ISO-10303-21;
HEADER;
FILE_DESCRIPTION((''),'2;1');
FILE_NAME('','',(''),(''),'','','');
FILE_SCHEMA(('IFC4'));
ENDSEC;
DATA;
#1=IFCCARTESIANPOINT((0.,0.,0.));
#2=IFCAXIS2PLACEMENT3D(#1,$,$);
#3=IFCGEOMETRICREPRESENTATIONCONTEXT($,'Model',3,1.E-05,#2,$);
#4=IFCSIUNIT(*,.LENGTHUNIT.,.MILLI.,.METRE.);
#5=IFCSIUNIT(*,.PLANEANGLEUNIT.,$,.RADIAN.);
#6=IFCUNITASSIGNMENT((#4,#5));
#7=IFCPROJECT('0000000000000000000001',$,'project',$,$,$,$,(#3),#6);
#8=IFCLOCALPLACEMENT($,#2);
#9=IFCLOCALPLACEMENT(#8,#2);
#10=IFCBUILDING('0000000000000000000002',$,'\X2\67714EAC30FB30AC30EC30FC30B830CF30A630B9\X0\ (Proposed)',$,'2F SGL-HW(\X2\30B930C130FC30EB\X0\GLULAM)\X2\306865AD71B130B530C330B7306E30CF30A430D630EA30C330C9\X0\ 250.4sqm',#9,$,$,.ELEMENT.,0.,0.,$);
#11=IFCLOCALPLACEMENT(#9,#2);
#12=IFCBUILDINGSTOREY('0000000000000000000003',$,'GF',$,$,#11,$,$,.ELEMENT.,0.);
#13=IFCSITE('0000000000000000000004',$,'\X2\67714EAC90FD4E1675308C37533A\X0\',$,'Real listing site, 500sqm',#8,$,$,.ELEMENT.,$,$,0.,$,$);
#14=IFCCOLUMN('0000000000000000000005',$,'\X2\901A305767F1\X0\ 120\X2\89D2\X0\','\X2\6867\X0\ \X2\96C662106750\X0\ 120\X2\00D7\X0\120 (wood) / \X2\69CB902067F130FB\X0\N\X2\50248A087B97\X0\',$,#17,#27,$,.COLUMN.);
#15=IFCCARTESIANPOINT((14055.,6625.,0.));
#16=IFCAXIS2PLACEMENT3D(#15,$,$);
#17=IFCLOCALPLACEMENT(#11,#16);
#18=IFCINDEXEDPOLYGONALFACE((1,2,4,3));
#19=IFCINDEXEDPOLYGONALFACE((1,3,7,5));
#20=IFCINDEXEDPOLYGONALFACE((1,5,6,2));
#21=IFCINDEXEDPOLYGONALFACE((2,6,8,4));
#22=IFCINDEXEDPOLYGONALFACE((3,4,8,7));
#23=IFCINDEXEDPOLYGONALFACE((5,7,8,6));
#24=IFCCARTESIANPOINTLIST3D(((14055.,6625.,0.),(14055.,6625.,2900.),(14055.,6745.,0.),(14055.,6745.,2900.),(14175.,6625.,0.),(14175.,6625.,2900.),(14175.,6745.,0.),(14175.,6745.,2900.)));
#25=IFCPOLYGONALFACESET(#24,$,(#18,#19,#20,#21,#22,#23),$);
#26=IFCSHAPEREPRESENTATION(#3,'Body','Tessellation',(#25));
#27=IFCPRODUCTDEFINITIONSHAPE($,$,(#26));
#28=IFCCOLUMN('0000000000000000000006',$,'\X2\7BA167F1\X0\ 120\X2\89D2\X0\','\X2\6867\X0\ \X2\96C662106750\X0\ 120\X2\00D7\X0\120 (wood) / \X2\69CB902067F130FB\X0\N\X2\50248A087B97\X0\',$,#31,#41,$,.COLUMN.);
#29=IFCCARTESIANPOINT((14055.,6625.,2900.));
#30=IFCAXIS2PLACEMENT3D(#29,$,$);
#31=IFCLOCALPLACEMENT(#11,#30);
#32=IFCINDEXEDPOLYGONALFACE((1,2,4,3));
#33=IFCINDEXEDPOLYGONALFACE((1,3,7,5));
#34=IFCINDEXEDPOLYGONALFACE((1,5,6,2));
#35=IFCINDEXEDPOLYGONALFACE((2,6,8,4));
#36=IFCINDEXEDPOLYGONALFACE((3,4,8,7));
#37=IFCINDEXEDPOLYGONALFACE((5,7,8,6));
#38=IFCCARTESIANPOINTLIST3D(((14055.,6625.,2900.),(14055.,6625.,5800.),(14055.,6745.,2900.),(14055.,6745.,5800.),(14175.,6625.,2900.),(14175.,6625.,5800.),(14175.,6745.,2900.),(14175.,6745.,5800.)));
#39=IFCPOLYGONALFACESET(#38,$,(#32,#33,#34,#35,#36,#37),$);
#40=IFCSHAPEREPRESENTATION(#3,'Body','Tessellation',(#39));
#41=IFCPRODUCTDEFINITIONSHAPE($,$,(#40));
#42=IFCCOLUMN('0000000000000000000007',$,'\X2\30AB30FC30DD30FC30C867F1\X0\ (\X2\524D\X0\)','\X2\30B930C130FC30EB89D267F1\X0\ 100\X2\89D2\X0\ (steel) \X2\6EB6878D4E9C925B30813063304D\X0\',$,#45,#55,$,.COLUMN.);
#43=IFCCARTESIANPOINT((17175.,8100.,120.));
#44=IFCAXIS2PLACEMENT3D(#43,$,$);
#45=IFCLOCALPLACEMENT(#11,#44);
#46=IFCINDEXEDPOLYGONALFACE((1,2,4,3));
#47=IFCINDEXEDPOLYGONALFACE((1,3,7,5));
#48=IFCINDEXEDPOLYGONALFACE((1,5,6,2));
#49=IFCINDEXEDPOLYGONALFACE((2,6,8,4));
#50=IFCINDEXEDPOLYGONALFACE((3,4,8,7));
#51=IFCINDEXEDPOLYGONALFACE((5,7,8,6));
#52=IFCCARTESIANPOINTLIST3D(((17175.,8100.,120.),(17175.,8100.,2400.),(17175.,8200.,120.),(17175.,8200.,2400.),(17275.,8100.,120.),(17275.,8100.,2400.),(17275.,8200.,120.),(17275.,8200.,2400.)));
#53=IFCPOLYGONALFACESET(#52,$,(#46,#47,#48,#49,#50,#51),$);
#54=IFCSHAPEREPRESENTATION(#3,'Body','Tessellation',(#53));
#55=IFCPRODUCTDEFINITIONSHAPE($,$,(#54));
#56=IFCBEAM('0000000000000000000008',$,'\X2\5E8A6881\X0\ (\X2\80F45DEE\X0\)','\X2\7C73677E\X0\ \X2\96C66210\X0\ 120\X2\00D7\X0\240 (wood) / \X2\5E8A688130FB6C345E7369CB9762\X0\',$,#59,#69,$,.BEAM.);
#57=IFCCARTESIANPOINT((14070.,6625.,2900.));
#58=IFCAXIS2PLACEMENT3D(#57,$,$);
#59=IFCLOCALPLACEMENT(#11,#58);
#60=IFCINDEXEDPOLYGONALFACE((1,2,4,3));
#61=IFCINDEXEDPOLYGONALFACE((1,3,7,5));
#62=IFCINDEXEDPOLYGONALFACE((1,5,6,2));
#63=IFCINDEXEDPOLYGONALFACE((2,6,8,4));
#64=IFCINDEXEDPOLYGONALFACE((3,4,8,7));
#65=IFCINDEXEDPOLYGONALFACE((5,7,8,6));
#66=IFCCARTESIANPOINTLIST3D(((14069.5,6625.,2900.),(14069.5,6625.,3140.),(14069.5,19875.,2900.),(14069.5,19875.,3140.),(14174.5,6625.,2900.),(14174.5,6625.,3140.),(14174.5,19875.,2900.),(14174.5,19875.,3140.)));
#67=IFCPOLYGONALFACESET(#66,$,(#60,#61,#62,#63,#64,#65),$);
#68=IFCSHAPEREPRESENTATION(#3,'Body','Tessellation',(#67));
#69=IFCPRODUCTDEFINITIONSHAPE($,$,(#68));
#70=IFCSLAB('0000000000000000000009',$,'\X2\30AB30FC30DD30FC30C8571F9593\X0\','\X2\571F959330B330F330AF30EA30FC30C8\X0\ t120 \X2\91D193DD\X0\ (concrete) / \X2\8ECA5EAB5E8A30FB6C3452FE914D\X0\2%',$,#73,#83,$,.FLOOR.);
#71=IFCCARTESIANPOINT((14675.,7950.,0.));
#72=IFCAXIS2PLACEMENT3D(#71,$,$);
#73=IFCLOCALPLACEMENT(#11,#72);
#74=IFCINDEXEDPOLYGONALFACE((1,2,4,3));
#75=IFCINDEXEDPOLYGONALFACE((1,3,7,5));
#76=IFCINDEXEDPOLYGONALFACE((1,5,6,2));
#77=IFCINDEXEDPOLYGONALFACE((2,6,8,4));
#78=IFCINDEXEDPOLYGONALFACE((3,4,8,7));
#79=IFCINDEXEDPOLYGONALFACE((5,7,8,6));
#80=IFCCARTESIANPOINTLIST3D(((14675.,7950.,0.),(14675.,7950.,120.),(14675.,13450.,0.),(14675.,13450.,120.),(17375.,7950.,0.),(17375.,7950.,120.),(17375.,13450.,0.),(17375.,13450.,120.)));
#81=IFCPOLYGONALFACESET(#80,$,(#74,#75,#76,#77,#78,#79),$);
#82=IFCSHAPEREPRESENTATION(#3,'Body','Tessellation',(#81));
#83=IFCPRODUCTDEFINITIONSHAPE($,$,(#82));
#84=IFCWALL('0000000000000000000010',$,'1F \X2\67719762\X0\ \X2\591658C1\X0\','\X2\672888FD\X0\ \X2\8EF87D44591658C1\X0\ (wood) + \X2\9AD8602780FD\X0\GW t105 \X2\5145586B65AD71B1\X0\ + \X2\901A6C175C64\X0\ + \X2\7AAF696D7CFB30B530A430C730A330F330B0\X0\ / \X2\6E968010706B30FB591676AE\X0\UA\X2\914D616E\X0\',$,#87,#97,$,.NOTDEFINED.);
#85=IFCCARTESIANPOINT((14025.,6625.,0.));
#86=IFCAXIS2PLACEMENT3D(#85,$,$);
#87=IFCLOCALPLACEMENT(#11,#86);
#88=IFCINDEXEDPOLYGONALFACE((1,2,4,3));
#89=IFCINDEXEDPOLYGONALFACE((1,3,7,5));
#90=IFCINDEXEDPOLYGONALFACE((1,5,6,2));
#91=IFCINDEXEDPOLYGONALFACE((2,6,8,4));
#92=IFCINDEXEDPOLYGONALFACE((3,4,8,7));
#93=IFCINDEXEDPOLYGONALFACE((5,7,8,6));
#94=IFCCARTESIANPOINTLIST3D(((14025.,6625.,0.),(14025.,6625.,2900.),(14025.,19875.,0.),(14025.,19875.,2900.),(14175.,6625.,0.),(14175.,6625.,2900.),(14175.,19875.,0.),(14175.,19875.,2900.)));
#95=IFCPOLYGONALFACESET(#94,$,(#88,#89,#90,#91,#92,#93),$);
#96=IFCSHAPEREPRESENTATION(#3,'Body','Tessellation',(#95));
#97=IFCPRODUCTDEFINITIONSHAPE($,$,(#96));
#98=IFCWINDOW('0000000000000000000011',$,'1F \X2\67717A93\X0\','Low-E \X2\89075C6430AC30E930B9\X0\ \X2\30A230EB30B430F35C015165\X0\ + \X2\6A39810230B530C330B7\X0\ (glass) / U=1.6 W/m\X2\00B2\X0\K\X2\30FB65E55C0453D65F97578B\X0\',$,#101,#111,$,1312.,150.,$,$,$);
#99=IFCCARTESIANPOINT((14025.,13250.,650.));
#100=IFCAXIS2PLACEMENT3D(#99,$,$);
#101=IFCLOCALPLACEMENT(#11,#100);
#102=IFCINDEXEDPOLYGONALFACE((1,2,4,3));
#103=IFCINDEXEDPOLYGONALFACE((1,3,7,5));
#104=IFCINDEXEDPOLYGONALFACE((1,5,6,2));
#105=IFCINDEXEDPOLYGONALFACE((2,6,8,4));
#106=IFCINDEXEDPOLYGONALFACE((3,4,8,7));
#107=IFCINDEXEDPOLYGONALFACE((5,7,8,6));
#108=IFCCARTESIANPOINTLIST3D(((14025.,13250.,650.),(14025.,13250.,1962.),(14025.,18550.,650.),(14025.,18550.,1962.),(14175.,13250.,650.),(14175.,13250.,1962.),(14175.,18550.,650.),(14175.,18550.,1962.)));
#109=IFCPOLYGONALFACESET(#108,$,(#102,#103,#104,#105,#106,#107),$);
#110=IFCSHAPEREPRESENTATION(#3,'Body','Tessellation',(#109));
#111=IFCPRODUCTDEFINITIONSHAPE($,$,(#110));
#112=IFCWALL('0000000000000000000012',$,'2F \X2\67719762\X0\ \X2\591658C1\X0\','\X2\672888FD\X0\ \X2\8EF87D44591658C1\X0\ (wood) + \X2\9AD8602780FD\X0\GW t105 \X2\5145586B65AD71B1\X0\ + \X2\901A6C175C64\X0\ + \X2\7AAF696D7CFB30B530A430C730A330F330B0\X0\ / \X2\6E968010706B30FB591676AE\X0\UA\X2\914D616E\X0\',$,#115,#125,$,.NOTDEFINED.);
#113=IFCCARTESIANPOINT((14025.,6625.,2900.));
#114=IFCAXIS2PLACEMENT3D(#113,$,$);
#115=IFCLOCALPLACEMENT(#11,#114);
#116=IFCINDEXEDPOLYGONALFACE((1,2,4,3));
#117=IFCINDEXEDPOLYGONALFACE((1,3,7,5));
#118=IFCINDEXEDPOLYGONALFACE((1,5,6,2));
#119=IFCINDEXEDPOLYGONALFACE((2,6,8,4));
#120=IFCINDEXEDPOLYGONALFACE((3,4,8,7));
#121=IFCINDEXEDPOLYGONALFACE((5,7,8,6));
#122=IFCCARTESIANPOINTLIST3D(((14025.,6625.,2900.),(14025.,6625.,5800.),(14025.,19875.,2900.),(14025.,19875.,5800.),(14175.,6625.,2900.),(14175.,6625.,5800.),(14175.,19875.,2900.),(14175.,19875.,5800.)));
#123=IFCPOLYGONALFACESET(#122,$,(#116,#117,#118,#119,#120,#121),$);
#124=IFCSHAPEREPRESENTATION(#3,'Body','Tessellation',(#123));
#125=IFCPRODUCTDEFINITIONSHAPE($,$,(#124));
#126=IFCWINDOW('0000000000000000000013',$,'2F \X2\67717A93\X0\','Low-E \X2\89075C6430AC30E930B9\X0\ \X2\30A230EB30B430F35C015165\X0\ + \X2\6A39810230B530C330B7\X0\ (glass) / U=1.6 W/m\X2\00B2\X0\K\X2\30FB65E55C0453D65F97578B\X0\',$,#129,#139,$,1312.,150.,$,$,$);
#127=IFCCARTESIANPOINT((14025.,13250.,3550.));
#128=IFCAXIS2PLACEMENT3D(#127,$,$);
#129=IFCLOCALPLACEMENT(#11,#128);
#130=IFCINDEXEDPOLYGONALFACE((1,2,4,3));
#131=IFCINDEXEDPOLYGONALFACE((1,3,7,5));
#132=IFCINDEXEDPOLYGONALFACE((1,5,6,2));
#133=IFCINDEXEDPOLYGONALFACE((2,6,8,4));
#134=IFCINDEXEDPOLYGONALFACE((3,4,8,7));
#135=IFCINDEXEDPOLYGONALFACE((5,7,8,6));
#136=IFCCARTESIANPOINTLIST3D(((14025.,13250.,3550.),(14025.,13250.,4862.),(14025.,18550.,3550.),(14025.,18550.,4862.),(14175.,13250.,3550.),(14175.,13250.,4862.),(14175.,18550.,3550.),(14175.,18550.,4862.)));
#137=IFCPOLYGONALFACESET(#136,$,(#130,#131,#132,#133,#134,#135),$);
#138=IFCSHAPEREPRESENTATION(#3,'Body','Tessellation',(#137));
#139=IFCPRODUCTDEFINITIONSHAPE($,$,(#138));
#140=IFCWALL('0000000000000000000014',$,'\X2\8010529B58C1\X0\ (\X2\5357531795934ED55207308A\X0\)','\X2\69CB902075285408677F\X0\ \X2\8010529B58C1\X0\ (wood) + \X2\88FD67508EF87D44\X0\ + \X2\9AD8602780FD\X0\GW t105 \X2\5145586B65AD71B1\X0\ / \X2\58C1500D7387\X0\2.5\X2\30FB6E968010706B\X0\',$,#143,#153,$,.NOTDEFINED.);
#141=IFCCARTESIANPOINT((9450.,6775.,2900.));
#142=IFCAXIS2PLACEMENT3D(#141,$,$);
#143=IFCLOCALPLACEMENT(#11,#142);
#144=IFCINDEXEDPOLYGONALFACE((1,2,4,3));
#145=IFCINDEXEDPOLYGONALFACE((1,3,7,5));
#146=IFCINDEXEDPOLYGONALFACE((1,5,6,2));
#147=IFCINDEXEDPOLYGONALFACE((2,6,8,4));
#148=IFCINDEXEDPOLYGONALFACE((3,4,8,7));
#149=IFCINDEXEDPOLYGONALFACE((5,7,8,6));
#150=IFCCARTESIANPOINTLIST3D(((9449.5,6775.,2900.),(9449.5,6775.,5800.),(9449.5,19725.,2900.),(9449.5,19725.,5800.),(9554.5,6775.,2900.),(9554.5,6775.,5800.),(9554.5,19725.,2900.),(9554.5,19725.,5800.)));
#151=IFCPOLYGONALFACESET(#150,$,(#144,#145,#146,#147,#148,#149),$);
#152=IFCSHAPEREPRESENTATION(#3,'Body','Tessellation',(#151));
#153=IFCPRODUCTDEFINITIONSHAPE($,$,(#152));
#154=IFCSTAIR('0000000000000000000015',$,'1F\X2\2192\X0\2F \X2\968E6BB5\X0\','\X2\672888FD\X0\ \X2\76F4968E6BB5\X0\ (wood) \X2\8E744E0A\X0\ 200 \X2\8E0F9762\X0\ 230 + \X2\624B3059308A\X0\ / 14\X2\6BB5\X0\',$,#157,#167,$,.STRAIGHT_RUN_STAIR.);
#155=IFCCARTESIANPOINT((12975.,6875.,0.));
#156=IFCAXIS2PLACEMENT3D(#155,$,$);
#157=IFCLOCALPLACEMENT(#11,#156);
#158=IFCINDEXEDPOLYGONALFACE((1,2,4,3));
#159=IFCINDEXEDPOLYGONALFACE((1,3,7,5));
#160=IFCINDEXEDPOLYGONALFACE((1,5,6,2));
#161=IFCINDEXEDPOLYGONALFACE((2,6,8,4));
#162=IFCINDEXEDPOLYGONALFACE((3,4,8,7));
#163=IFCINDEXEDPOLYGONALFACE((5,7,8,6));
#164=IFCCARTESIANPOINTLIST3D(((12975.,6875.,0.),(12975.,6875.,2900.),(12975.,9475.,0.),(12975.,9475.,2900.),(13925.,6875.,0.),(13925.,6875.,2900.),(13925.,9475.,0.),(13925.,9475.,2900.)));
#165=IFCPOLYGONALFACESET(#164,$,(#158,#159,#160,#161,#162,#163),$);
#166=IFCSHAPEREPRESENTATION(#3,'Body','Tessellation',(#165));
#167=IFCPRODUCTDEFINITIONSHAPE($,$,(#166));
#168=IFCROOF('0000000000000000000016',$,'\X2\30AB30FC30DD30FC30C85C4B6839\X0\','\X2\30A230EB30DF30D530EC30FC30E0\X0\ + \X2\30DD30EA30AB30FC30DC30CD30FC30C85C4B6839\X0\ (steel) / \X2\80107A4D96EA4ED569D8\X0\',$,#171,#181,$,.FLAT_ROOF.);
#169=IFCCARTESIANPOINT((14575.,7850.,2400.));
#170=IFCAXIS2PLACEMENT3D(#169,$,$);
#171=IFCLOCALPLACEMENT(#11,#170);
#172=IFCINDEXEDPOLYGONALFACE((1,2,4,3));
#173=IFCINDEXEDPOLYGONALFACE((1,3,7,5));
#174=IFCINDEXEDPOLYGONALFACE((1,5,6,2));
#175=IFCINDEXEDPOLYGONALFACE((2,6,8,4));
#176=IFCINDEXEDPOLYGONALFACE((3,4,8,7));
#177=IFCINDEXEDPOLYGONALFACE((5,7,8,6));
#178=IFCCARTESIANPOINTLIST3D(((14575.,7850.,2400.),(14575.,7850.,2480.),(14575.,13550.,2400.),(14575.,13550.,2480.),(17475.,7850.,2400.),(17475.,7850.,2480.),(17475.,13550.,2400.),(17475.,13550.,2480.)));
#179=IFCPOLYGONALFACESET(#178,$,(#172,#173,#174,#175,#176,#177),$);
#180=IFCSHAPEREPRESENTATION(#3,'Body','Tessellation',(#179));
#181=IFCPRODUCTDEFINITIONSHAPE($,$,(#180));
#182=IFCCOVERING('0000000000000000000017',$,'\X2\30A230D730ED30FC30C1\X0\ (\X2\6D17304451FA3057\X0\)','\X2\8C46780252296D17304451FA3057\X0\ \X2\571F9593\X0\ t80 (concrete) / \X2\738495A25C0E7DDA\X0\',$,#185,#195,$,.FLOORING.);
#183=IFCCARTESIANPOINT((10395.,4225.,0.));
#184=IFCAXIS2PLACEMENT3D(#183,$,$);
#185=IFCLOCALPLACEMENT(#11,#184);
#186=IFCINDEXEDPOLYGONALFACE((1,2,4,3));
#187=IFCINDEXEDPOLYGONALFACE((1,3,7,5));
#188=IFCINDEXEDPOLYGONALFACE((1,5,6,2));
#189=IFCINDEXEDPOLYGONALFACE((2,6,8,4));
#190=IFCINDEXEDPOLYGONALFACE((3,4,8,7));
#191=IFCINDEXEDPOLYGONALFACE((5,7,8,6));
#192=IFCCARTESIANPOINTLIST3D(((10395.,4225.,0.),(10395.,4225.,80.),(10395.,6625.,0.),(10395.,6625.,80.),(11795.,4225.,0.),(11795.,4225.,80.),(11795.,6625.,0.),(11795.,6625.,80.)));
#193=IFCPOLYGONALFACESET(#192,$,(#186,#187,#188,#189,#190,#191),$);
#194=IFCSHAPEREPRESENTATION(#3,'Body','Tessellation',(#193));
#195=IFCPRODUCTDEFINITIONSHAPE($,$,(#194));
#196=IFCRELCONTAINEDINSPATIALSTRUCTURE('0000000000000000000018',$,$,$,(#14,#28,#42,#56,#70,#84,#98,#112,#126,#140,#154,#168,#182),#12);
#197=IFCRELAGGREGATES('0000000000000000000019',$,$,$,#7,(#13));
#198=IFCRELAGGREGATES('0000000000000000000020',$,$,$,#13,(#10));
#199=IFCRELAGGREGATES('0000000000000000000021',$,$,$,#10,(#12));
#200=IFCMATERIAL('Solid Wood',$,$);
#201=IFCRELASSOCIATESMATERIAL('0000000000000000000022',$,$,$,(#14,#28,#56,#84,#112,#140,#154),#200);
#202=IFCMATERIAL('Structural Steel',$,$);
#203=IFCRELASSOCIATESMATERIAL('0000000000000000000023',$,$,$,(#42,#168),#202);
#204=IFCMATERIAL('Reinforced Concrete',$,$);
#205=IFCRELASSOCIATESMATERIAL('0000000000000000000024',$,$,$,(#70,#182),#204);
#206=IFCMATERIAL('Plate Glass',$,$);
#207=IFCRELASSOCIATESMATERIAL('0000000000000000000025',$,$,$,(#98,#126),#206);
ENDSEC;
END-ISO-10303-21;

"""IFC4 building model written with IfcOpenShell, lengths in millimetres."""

from ifc_helpers import new_model, si_unit, frame, frame_2d, origin, place, context, project, spatial, rectangle, extrude, material, element, fill, save


model = new_model("IFC4")

# Units and contexts
model_context = context("Model", 3, precision=1e-05, world=origin())
ifc_project = project(units=[si_unit("LENGTHUNIT", "METRE", prefix="MILLI"), si_unit("PLANEANGLEUNIT", "RADIAN")], contexts=[model_context])

# Site, building, storey
site_placement = place(None, origin())
site = spatial("IfcSite", under=ifc_project, at=site_placement, Name="東京都世田谷区", ObjectType="Real listing site, 500sqm", CompositionType="ELEMENT", RefElevation=0.0)
building_placement = place(site_placement, origin())
building = spatial("IfcBuilding", under=site, at=building_placement, Name="東京・ガレージハウス (Proposed)", ObjectType="2F SGL-HW(スチールGLULAM)と断熱サッシのハイブリッド 250.4sqm", CompositionType="ELEMENT", ElevationOfRefHeight=0.0, ElevationOfTerrain=0.0)
storey_placement = place(building_placement, origin())
storey = spatial("IfcBuildingStorey", under=building, at=storey_placement, Name="GF", CompositionType="ELEMENT", Elevation=0.0)

# Columns
ifc_material_1 = material(Name="Solid Wood")
column_1_placement = place(storey_placement, frame((14055.0, 6625.0, 0.0)))
element("IfcColumn", 1, at=column_1_placement, inside=storey, material=ifc_material_1, Name="通し柱 120角", Description="桧 集成材 120×120 (wood) / 構造柱・N値計算", PredefinedType="COLUMN", context=model_context, shape_type="SweptSolid", body=[
    extrude(rectangle(XDim=120.0, YDim=120.0, at=frame_2d((60.0, 60.0))), frame((14055.0, 6625.0, 0.0)), (0.0, 0.0, 1.0), 2900.0),
])
column_2_placement = place(storey_placement, frame((14055.0, 6625.0, 2900.0)))
element("IfcColumn", 2, at=column_2_placement, inside=storey, material=ifc_material_1, Name="管柱 120角", Description="桧 集成材 120×120 (wood) / 構造柱・N値計算", PredefinedType="COLUMN", context=model_context, shape_type="SweptSolid", body=[
    extrude(rectangle(XDim=120.0, YDim=120.0, at=frame_2d((60.0, 60.0))), frame((14055.0, 6625.0, 2900.0)), (0.0, 0.0, 1.0), 2900.0),
])
ifc_material_2 = material(Name="Structural Steel")
column_3_placement = place(storey_placement, frame((17175.0, 8100.0, 120.0)))
element("IfcColumn", 3, at=column_3_placement, inside=storey, material=ifc_material_2, Name="カーポート柱 (前)", Description="スチール角柱 100角 (steel) 溶融亜鉛めっき", PredefinedType="COLUMN", context=model_context, shape_type="SweptSolid", body=[
    extrude(rectangle(XDim=100.0, YDim=100.0, at=frame_2d((50.0, 50.0))), frame((17175.0, 8100.0, 120.0)), (0.0, 0.0, 1.0), 2280.0),
])

# Beam
beam_1_placement = place(storey_placement, frame((14070.0, 6625.0, 2900.0)))
element("IfcBeam", 4, at=beam_1_placement, inside=storey, material=ifc_material_1, Name="床梁 (胴差)", Description="米松 集成 120×240 (wood) / 床梁・水平構面", PredefinedType="BEAM", context=model_context, shape_type="SweptSolid", body=[
    extrude(rectangle(XDim=105.0, YDim=13250.0, at=frame_2d((52.0, 6625.0))), frame((14070.0, 6625.0, 2900.0)), (0.0, 0.0, 1.0), 240.0),
])

# Slab
ifc_material_3 = material(Name="Reinforced Concrete")
slab_placement = place(storey_placement, frame((14675.0, 7950.0, 0.0)))
element("IfcSlab", 5, at=slab_placement, inside=storey, material=ifc_material_3, Name="カーポート土間", Description="土間コンクリート t120 金鏝 (concrete) / 車庫床・水勾配2%", PredefinedType="FLOOR", context=model_context, shape_type="SweptSolid", body=[
    extrude(rectangle(XDim=2700.0, YDim=5500.0, at=frame_2d((1350.0, 2750.0))), frame((14675.0, 7950.0, 0.0)), (0.0, 0.0, 1.0), 120.0),
])

# Wall, opening, window
wall_1_placement = place(storey_placement, frame((14025.0, 6625.0, 0.0)))
wall_1 = element("IfcWall", 6, at=wall_1_placement, inside=storey, material=ifc_material_1, Name="1F 東面 外壁", Description="木製 軸組外壁 (wood) + 高性能GW t105 充填断熱 + 通気層 + 窯業系サイディング / 準耐火・外皮UA配慮", PredefinedType="NOTDEFINED", context=model_context, shape_type="SweptSolid", body=[
    extrude(rectangle(XDim=150.0, YDim=13250.0, at=frame_2d((75.0, 6625.0))), frame((14025.0, 6625.0, 0.0)), (0.0, 0.0, 1.0), 2900.0),
])
opening_1_placement = place(storey_placement, frame((14025.0, 13250.0, 650.0)))
opening_1 = element("IfcOpeningElement", 7, at=opening_1_placement, cuts=wall_1, PredefinedType="NOTDEFINED", context=model_context, shape_type="SweptSolid", body=[
    extrude(rectangle(XDim=150.0, YDim=5300.0, at=frame_2d((75.0, 2650.0))), frame((14025.0, 13250.0, 650.0)), (0.0, 0.0, 1.0), 1312.0),
])
ifc_material_4 = material(Name="Plate Glass")
window_1_placement = place(storey_placement, frame((14025.0, 13250.0, 650.0)))
window_1 = element("IfcWindow", 8, at=window_1_placement, inside=storey, material=ifc_material_4, Name="1F 東窓", Description="Low-E 複層ガラス アルゴン封入 + 樹脂サッシ (glass) / U=1.6 W/m²K・日射取得型", OverallHeight=1312.0, OverallWidth=150.0, context=model_context, shape_type="SweptSolid", body=[
    extrude(rectangle(XDim=150.0, YDim=5300.0, at=frame_2d((75.0, 2650.0))), frame((14025.0, 13250.0, 650.0)), (0.0, 0.0, 1.0), 1312.0),
])
fill(opening_1, window_1)

# Wall, opening, window
wall_2_placement = place(storey_placement, frame((14025.0, 6625.0, 2900.0)))
wall_2 = element("IfcWall", 9, at=wall_2_placement, inside=storey, material=ifc_material_1, Name="2F 東面 外壁", Description="木製 軸組外壁 (wood) + 高性能GW t105 充填断熱 + 通気層 + 窯業系サイディング / 準耐火・外皮UA配慮", PredefinedType="NOTDEFINED", context=model_context, shape_type="SweptSolid", body=[
    extrude(rectangle(XDim=150.0, YDim=13250.0, at=frame_2d((75.0, 6625.0))), frame((14025.0, 6625.0, 2900.0)), (0.0, 0.0, 1.0), 2900.0),
])
opening_2_placement = place(storey_placement, frame((14025.0, 13250.0, 3550.0)))
opening_2 = element("IfcOpeningElement", 10, at=opening_2_placement, cuts=wall_2, PredefinedType="NOTDEFINED", context=model_context, shape_type="SweptSolid", body=[
    extrude(rectangle(XDim=150.0, YDim=5300.0, at=frame_2d((75.0, 2650.0))), frame((14025.0, 13250.0, 3550.0)), (0.0, 0.0, 1.0), 1312.0),
])
window_2_placement = place(storey_placement, frame((14025.0, 13250.0, 3550.0)))
window_2 = element("IfcWindow", 11, at=window_2_placement, inside=storey, material=ifc_material_4, Name="2F 東窓", Description="Low-E 複層ガラス アルゴン封入 + 樹脂サッシ (glass) / U=1.6 W/m²K・日射取得型", OverallHeight=1312.0, OverallWidth=150.0, context=model_context, shape_type="SweptSolid", body=[
    extrude(rectangle(XDim=150.0, YDim=5300.0, at=frame_2d((75.0, 2650.0))), frame((14025.0, 13250.0, 3550.0)), (0.0, 0.0, 1.0), 1312.0),
])
fill(opening_2, window_2)

# Wall
wall_3_placement = place(storey_placement, frame((9450.0, 6775.0, 2900.0)))
element("IfcWall", 12, at=wall_3_placement, inside=storey, material=ifc_material_1, Name="耐力壁 (南北間仕切り)", Description="構造用合板 耐力壁 (wood) + 製材軸組 + 高性能GW t105 充填断熱 / 壁倍率2.5・準耐火", PredefinedType="NOTDEFINED", context=model_context, shape_type="SweptSolid", body=[
    extrude(rectangle(XDim=105.0, YDim=12950.0, at=frame_2d((52.0, 6475.0))), frame((9450.0, 6775.0, 2900.0)), (0.0, 0.0, 1.0), 2900.0),
])

# Stair
stair_placement = place(storey_placement, frame((12975.0, 6875.0, 0.0)))
element("IfcStair", 13, at=stair_placement, inside=storey, material=ifc_material_1, Name="1F→2F 階段", Description="木製 直階段 (wood) 蹴上 200 踏面 230 + 手すり / 14段", PredefinedType="STRAIGHT_RUN_STAIR", context=model_context, shape_type="SweptSolid", body=[
    extrude(rectangle(XDim=950.0, YDim=2600.0, at=frame_2d((475.0, 1300.0))), frame((12975.0, 6875.0, 0.0)), (0.0, 0.0, 1.0), 2900.0),
])

# Roof
roof_placement = place(storey_placement, frame((14575.0, 7850.0, 2400.0)))
element("IfcRoof", 14, at=roof_placement, inside=storey, material=ifc_material_2, Name="カーポート屋根", Description="アルミフレーム + ポリカーボネート屋根 (steel) / 耐積雪仕様", PredefinedType="FLAT_ROOF", context=model_context, shape_type="SweptSolid", body=[
    extrude(rectangle(XDim=2900.0, YDim=5700.0, at=frame_2d((1450.0, 2850.0))), frame((14575.0, 7850.0, 2400.0)), (0.0, 0.0, 1.0), 80.0),
])

# Covering
covering_placement = place(storey_placement, frame((10395.0, 4225.0, 0.0)))
element("IfcCovering", 15, at=covering_placement, inside=storey, material=ifc_material_3, Name="アプローチ (洗い出し)", Description="豆砂利洗い出し 土間 t80 (concrete) / 玄関導線", PredefinedType="FLOORING", context=model_context, shape_type="SweptSolid", body=[
    extrude(rectangle(XDim=1400.0, YDim=2400.0, at=frame_2d((700.0, 1200.0))), frame((10395.0, 4225.0, 0.0)), (0.0, 0.0, 1.0), 80.0),
])

save(model, "model.ifc")
